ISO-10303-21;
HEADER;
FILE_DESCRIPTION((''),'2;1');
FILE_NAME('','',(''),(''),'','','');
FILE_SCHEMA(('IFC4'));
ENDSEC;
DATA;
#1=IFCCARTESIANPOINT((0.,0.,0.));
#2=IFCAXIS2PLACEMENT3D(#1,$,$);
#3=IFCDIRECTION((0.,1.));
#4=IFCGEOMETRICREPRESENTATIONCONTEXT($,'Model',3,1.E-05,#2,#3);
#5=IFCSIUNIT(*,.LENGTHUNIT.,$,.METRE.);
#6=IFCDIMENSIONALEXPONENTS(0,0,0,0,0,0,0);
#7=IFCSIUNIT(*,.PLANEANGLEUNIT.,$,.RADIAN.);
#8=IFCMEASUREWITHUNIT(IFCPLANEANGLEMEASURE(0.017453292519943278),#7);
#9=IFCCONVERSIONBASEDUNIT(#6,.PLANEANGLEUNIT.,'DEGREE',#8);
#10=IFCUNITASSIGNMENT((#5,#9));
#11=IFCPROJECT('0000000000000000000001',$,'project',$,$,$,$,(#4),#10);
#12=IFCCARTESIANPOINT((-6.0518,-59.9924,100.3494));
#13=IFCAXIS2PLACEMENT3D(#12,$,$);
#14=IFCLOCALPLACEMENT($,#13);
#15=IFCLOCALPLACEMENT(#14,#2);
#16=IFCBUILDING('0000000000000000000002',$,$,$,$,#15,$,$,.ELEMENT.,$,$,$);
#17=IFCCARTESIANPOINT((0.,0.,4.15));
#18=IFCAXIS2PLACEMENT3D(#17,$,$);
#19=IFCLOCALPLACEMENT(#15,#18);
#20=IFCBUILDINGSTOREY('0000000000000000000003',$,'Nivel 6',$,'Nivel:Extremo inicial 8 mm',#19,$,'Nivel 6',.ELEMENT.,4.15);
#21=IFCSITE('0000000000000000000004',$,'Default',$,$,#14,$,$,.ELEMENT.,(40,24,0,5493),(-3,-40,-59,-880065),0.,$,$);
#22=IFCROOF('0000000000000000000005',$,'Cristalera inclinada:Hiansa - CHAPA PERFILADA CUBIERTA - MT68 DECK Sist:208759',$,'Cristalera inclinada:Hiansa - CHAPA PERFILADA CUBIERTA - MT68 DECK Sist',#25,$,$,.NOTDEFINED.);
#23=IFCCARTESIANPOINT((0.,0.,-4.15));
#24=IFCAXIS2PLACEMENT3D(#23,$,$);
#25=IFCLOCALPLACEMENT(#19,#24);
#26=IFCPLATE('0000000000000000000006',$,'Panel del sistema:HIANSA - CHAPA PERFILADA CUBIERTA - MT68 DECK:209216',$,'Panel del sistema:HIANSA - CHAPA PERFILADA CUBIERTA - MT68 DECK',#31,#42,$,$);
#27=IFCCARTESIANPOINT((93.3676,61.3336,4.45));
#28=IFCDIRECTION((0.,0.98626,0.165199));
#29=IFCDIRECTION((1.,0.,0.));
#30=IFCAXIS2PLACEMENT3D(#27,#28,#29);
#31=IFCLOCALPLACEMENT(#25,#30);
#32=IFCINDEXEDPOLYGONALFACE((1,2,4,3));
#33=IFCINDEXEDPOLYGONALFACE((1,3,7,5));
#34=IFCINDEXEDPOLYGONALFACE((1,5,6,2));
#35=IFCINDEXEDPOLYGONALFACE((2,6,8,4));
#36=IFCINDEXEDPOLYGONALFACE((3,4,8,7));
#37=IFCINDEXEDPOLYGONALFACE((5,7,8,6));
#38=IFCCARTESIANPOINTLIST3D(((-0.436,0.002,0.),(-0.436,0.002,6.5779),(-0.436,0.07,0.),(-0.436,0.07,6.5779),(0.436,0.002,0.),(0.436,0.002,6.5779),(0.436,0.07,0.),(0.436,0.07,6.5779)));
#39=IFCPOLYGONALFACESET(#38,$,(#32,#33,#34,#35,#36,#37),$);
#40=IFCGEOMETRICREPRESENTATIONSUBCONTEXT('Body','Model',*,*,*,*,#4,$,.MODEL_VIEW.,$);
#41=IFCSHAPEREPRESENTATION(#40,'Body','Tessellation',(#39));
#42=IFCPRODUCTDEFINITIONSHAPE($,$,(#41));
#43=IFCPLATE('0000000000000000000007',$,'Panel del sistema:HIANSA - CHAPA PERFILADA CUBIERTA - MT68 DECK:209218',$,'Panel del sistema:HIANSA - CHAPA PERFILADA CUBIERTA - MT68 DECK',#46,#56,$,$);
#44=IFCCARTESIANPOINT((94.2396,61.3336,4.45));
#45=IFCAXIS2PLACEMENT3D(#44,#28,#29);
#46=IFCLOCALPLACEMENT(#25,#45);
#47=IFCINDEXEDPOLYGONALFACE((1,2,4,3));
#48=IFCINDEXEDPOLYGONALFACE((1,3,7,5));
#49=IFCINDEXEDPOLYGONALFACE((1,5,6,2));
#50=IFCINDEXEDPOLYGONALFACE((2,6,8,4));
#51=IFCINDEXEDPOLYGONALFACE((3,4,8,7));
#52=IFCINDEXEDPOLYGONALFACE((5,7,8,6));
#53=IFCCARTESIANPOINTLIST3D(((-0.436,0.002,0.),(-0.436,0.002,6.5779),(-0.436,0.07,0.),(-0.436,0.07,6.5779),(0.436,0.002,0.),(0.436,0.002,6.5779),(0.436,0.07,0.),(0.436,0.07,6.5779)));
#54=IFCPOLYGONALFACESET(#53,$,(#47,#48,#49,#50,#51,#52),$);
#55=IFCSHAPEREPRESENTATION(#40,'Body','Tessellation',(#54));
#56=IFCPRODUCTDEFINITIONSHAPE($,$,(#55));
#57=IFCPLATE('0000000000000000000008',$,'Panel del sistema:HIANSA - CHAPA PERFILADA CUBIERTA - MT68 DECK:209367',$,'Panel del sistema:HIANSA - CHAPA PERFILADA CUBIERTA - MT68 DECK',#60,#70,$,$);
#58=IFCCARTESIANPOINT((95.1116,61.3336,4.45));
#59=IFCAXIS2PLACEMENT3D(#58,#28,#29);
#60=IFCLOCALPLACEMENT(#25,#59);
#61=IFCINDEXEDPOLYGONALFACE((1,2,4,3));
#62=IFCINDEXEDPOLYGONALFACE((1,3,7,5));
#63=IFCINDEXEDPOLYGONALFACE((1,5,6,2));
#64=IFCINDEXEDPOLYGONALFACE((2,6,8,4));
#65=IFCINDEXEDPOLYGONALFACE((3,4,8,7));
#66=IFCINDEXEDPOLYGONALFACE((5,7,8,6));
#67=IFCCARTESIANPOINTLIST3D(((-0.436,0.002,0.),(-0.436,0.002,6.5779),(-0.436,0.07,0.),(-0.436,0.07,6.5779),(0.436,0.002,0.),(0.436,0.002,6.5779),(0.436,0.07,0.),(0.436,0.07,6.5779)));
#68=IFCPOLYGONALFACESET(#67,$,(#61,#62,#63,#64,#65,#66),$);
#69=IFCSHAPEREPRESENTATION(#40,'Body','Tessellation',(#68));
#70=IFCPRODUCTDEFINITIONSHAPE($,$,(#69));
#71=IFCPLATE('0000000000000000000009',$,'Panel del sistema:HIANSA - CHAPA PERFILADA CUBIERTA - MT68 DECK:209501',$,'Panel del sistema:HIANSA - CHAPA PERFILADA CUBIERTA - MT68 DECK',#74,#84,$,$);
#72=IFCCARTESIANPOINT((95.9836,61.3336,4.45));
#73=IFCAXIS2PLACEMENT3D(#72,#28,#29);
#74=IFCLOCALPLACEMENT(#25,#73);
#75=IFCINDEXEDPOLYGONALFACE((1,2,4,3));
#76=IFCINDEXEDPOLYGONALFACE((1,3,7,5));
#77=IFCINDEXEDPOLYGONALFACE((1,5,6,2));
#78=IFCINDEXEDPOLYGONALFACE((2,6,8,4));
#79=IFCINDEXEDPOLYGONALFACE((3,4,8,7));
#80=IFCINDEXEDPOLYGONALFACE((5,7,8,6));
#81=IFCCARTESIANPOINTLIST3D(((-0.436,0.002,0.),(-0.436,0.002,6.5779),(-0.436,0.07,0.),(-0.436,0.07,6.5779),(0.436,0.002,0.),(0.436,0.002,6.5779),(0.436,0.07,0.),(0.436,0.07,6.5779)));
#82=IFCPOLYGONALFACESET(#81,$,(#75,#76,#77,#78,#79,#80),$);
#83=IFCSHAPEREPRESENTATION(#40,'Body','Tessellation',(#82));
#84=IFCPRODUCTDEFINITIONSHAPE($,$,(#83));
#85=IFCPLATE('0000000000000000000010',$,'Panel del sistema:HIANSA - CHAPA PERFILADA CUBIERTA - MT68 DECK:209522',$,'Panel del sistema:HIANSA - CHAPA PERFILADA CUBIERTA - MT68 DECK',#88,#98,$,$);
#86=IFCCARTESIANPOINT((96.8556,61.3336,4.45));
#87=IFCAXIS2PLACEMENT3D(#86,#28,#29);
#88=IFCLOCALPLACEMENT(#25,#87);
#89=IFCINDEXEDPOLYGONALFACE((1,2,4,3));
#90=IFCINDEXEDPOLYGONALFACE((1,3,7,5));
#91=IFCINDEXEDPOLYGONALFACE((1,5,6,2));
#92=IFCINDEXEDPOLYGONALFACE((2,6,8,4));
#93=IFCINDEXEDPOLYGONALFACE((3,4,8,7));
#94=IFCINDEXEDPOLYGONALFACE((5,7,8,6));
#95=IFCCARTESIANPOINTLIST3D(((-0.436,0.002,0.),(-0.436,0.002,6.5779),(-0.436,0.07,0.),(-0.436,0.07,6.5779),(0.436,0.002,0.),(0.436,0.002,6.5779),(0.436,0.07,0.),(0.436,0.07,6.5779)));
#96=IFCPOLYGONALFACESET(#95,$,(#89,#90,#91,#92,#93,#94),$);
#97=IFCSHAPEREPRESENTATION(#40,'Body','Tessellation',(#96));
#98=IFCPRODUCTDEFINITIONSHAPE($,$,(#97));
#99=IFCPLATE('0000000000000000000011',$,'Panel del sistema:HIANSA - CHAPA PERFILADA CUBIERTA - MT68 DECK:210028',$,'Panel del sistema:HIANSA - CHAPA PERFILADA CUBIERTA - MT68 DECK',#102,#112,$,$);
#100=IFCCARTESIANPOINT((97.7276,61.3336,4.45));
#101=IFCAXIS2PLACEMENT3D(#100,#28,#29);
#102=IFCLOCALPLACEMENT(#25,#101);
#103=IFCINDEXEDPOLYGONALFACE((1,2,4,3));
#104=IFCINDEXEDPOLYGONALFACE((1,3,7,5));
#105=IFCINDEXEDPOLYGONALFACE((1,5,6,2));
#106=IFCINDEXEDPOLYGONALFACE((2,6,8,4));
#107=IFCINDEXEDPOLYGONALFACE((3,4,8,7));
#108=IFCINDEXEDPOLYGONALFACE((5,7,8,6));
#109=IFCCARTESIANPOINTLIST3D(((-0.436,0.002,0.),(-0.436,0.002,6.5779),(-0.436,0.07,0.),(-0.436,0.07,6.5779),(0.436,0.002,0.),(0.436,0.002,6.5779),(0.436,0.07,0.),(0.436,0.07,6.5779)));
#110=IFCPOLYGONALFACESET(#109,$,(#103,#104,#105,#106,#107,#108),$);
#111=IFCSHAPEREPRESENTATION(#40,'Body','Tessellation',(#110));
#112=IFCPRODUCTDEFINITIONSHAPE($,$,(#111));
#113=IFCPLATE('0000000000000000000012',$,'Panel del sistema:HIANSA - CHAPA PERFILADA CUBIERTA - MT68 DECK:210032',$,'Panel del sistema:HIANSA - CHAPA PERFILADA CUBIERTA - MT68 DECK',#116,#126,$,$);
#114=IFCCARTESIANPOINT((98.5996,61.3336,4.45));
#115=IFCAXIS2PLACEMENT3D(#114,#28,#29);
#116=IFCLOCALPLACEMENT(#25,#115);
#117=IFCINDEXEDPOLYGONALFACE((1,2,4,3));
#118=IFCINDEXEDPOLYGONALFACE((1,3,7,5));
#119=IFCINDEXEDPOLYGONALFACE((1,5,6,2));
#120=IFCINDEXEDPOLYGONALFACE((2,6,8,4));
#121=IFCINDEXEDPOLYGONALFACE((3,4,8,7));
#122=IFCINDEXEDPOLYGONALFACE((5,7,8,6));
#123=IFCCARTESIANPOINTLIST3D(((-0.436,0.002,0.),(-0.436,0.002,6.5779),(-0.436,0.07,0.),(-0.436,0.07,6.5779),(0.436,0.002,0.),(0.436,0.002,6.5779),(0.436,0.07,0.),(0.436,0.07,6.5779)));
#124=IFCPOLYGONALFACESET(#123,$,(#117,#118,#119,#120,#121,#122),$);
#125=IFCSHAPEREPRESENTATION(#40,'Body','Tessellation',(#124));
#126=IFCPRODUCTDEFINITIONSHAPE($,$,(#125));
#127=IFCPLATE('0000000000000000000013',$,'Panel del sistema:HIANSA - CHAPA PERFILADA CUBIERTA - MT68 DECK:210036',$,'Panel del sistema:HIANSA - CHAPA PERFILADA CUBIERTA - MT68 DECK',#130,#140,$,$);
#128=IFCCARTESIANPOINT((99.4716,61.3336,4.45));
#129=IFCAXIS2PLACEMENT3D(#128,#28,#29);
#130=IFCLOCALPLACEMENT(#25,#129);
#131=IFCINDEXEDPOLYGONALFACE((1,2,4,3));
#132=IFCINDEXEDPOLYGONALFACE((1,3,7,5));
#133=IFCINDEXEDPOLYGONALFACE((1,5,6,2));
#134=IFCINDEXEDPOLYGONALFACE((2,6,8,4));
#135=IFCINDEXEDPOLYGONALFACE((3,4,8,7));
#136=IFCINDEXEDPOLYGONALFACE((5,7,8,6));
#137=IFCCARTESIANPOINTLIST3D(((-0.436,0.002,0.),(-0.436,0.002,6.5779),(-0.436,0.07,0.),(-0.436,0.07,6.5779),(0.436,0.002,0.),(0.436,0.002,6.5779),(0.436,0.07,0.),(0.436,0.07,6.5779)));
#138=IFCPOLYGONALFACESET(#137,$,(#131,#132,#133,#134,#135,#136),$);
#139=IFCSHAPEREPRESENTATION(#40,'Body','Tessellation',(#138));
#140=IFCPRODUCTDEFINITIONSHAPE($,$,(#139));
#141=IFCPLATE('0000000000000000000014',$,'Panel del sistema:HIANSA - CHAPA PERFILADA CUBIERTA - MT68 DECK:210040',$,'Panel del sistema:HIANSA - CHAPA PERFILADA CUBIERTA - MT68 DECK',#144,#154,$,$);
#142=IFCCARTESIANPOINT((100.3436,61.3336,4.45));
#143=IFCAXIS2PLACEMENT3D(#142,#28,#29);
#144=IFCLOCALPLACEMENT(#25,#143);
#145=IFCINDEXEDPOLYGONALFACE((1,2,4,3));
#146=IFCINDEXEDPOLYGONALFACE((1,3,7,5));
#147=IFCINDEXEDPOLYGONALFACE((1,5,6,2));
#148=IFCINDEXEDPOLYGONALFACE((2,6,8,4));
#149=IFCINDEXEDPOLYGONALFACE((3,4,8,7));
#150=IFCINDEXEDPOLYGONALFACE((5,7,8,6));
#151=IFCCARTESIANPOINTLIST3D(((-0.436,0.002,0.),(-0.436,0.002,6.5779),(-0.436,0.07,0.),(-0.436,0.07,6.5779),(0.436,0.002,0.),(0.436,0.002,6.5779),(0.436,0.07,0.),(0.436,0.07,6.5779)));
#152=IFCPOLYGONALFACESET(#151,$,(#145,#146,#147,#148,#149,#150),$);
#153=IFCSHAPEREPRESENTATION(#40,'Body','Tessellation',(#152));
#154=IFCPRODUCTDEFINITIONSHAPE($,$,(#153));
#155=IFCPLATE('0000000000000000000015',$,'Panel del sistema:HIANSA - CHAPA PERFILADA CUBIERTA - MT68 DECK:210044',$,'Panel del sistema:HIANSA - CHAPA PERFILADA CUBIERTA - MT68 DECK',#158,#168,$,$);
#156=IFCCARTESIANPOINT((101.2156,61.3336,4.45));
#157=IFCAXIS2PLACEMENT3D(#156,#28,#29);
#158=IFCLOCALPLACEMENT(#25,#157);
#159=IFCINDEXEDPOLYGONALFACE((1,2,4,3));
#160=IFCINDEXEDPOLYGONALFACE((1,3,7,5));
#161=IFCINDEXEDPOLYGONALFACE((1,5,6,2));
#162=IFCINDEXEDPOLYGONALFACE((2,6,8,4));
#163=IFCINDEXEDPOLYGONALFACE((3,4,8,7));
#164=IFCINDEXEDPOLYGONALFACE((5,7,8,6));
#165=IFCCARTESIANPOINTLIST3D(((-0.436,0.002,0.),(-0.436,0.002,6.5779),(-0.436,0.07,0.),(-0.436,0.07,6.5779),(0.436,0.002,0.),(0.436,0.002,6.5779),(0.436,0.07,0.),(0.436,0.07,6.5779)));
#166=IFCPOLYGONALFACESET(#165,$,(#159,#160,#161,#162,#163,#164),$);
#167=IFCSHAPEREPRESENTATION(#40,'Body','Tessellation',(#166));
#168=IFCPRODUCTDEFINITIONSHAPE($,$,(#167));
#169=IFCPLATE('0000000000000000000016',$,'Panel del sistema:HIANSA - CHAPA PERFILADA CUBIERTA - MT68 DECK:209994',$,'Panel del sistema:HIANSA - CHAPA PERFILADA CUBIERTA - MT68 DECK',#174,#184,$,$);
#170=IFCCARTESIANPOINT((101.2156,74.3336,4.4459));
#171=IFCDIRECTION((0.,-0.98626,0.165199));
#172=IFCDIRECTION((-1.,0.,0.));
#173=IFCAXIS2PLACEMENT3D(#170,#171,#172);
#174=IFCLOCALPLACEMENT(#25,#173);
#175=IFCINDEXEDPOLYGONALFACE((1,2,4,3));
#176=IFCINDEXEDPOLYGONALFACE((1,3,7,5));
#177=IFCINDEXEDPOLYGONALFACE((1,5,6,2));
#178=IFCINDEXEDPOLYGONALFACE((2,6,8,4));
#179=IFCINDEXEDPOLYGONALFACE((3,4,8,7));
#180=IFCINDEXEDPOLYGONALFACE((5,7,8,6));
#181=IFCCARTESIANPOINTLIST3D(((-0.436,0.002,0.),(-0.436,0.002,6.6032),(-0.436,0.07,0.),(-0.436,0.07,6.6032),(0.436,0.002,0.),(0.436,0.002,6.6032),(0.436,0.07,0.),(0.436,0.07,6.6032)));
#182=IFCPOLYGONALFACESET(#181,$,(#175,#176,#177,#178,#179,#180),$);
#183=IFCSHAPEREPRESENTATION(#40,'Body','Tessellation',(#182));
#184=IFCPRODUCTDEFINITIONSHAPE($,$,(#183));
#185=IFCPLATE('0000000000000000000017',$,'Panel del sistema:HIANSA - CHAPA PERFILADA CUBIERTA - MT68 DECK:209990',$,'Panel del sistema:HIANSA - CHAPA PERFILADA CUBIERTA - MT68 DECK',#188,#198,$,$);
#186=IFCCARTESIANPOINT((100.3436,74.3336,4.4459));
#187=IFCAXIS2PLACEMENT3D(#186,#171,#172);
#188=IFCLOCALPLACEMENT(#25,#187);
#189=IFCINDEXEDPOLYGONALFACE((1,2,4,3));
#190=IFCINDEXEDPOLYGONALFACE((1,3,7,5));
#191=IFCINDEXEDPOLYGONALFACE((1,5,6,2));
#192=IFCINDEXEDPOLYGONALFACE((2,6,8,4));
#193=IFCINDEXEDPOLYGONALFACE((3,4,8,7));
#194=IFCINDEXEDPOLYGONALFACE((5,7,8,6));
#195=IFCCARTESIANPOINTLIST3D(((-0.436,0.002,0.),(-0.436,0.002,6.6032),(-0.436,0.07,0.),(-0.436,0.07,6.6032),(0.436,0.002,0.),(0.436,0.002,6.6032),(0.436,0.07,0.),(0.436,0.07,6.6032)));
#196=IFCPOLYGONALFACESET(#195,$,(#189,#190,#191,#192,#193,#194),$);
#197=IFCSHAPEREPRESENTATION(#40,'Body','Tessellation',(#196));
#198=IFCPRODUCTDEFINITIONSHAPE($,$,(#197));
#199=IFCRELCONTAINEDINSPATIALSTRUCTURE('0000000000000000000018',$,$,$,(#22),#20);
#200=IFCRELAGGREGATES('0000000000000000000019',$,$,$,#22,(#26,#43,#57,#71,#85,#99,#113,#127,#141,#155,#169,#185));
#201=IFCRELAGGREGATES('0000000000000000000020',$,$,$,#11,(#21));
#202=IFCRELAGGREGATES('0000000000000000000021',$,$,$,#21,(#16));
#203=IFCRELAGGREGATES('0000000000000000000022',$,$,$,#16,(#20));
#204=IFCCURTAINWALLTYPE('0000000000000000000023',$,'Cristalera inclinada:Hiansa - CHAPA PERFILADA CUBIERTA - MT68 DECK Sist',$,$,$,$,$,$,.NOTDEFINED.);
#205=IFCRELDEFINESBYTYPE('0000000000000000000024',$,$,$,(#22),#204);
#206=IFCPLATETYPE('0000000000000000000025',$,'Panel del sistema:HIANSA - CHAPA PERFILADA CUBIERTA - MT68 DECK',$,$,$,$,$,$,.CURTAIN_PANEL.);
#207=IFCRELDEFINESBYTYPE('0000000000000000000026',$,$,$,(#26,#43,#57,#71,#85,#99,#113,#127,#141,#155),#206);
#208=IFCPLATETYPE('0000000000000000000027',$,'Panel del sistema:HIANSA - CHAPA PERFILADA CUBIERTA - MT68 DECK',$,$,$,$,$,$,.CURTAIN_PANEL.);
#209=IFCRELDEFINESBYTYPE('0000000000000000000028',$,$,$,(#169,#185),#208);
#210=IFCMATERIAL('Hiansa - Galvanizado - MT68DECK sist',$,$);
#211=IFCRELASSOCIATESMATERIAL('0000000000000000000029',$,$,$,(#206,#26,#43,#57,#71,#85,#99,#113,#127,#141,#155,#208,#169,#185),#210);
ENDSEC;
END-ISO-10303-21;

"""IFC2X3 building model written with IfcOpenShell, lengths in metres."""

from ifc_helpers import new_model, entity, si_unit, converted_unit, direction, frame, origin, origin_2d_with_axis, place, context, subcontext, project, spatial, rectangle, extrude, source, transform, mapped, material, type_object, type_shapes, element, aggregate, save


model = new_model("IFC2X3")

# Units and contexts
model_context = context("Model", 3, precision=1e-05, world=origin(), true_north=direction((0.0, 1.0)))
body_context = subcontext(model_context, "Body", "Model", "MODEL_VIEW")
ifc_project = project(units=[si_unit("LENGTHUNIT", "METRE"), converted_unit("PLANEANGLEUNIT", "DEGREE", entity("IfcPlaneAngleMeasure", 0.017453292519943278), si_unit("PLANEANGLEUNIT", "RADIAN"), dimensions=[0, 0, 0, 0, 0, 0, 0])], contexts=[model_context])

# Site, building, storey
site_placement = place(None, frame((-6.0518, -59.9924, 100.3494)))
site = spatial("IfcSite", under=ifc_project, at=site_placement, Name="Default", CompositionType="ELEMENT", RefLatitude=(40, 24, 0, 5493), RefLongitude=(-3, -40, -59, -880065), RefElevation=0.0)
building_placement = place(site_placement, origin())
building = spatial("IfcBuilding", under=site, at=building_placement, CompositionType="ELEMENT")
storey_placement = place(building_placement, frame((0.0, 0.0, 4.15)))
storey = spatial("IfcBuildingStorey", under=building, at=storey_placement, Name="Nivel 6", ObjectType="Nivel:Extremo inicial 8 mm", LongName="Nivel 6", CompositionType="ELEMENT", Elevation=4.15)

# Roof, plates
curtain_wall_type = type_object("IfcCurtainWallType", Name="Cristalera inclinada:Hiansa - CHAPA PERFILADA CUBIERTA - MT68 DECK Sist", PredefinedType="NOTDEFINED")
roof_placement = place(storey_placement, frame((0.0, 0.0, -4.15)))
roof = element("IfcRoof", 1, at=roof_placement, inside=storey, type_object=curtain_wall_type, Name="Cristalera inclinada:Hiansa - CHAPA PERFILADA CUBIERTA - MT68 DECK Sist:208759", ObjectType="Cristalera inclinada:Hiansa - CHAPA PERFILADA CUBIERTA - MT68 DECK Sist", ShapeType="NOTDEFINED")
ifc_material_1 = material(Name="Hiansa - Galvanizado - MT68DECK sist")
plate_type_1 = type_object("IfcPlateType", Name="Panel del sistema:HIANSA - CHAPA PERFILADA CUBIERTA - MT68 DECK", PredefinedType="CURTAIN_PANEL", material=ifc_material_1)
shared_shape_1 = source(origin(), body_context, "Body", "SweptSolid", [
    extrude(rectangle(XDim=0.068, YDim=0.872, at=origin_2d_with_axis()), frame((0.0, 0.036, 0.0), z_axis=(0.0, 0.0, 1.0), x_axis=(0.0, 1.0, 0.0)), (0.0, 0.0, 1.0), 6.5779),
])
type_shapes(plate_type_1, [shared_shape_1])
plate_1_placement = place(roof_placement, frame((93.3676, 61.3336, 4.45), z_axis=(0.0, 0.98626, 0.165199), x_axis=(1.0, 0.0, 0.0)))
plate_1 = element("IfcPlate", 2, at=plate_1_placement, type_object=plate_type_1, material=ifc_material_1, Name="Panel del sistema:HIANSA - CHAPA PERFILADA CUBIERTA - MT68 DECK:209216", ObjectType="Panel del sistema:HIANSA - CHAPA PERFILADA CUBIERTA - MT68 DECK", context=body_context, shape_type="MappedRepresentation", body=[
    mapped(shared_shape_1, transform((0.0, 0.0, 0.0), scale=1.0)),
])
plate_2_placement = place(roof_placement, frame((94.2396, 61.3336, 4.45), z_axis=(0.0, 0.98626, 0.165199), x_axis=(1.0, 0.0, 0.0)))
plate_2 = element("IfcPlate", 3, at=plate_2_placement, type_object=plate_type_1, material=ifc_material_1, Name="Panel del sistema:HIANSA - CHAPA PERFILADA CUBIERTA - MT68 DECK:209218", ObjectType="Panel del sistema:HIANSA - CHAPA PERFILADA CUBIERTA - MT68 DECK", context=body_context, shape_type="MappedRepresentation", body=[
    mapped(shared_shape_1, transform((0.0, 0.0, 0.0), scale=1.0)),
])
plate_3_placement = place(roof_placement, frame((95.1116, 61.3336, 4.45), z_axis=(0.0, 0.98626, 0.165199), x_axis=(1.0, 0.0, 0.0)))
plate_3 = element("IfcPlate", 4, at=plate_3_placement, type_object=plate_type_1, material=ifc_material_1, Name="Panel del sistema:HIANSA - CHAPA PERFILADA CUBIERTA - MT68 DECK:209367", ObjectType="Panel del sistema:HIANSA - CHAPA PERFILADA CUBIERTA - MT68 DECK", context=body_context, shape_type="MappedRepresentation", body=[
    mapped(shared_shape_1, transform((0.0, 0.0, 0.0), scale=1.0)),
])
plate_4_placement = place(roof_placement, frame((95.9836, 61.3336, 4.45), z_axis=(0.0, 0.98626, 0.165199), x_axis=(1.0, 0.0, 0.0)))
plate_4 = element("IfcPlate", 5, at=plate_4_placement, type_object=plate_type_1, material=ifc_material_1, Name="Panel del sistema:HIANSA - CHAPA PERFILADA CUBIERTA - MT68 DECK:209501", ObjectType="Panel del sistema:HIANSA - CHAPA PERFILADA CUBIERTA - MT68 DECK", context=body_context, shape_type="MappedRepresentation", body=[
    mapped(shared_shape_1, transform((0.0, 0.0, 0.0), scale=1.0)),
])
plate_5_placement = place(roof_placement, frame((96.8556, 61.3336, 4.45), z_axis=(0.0, 0.98626, 0.165199), x_axis=(1.0, 0.0, 0.0)))
plate_5 = element("IfcPlate", 6, at=plate_5_placement, type_object=plate_type_1, material=ifc_material_1, Name="Panel del sistema:HIANSA - CHAPA PERFILADA CUBIERTA - MT68 DECK:209522", ObjectType="Panel del sistema:HIANSA - CHAPA PERFILADA CUBIERTA - MT68 DECK", context=body_context, shape_type="MappedRepresentation", body=[
    mapped(shared_shape_1, transform((0.0, 0.0, 0.0), scale=1.0)),
])
plate_6_placement = place(roof_placement, frame((97.7276, 61.3336, 4.45), z_axis=(0.0, 0.98626, 0.165199), x_axis=(1.0, 0.0, 0.0)))
plate_6 = element("IfcPlate", 7, at=plate_6_placement, type_object=plate_type_1, material=ifc_material_1, Name="Panel del sistema:HIANSA - CHAPA PERFILADA CUBIERTA - MT68 DECK:210028", ObjectType="Panel del sistema:HIANSA - CHAPA PERFILADA CUBIERTA - MT68 DECK", context=body_context, shape_type="MappedRepresentation", body=[
    mapped(shared_shape_1, transform((0.0, 0.0, 0.0), scale=1.0)),
])
plate_7_placement = place(roof_placement, frame((98.5996, 61.3336, 4.45), z_axis=(0.0, 0.98626, 0.165199), x_axis=(1.0, 0.0, 0.0)))
plate_7 = element("IfcPlate", 8, at=plate_7_placement, type_object=plate_type_1, material=ifc_material_1, Name="Panel del sistema:HIANSA - CHAPA PERFILADA CUBIERTA - MT68 DECK:210032", ObjectType="Panel del sistema:HIANSA - CHAPA PERFILADA CUBIERTA - MT68 DECK", context=body_context, shape_type="MappedRepresentation", body=[
    mapped(shared_shape_1, transform((0.0, 0.0, 0.0), scale=1.0)),
])
plate_8_placement = place(roof_placement, frame((99.4716, 61.3336, 4.45), z_axis=(0.0, 0.98626, 0.165199), x_axis=(1.0, 0.0, 0.0)))
plate_8 = element("IfcPlate", 9, at=plate_8_placement, type_object=plate_type_1, material=ifc_material_1, Name="Panel del sistema:HIANSA - CHAPA PERFILADA CUBIERTA - MT68 DECK:210036", ObjectType="Panel del sistema:HIANSA - CHAPA PERFILADA CUBIERTA - MT68 DECK", context=body_context, shape_type="MappedRepresentation", body=[
    mapped(shared_shape_1, transform((0.0, 0.0, 0.0), scale=1.0)),
])
plate_9_placement = place(roof_placement, frame((100.3436, 61.3336, 4.45), z_axis=(0.0, 0.98626, 0.165199), x_axis=(1.0, 0.0, 0.0)))
plate_9 = element("IfcPlate", 10, at=plate_9_placement, type_object=plate_type_1, material=ifc_material_1, Name="Panel del sistema:HIANSA - CHAPA PERFILADA CUBIERTA - MT68 DECK:210040", ObjectType="Panel del sistema:HIANSA - CHAPA PERFILADA CUBIERTA - MT68 DECK", context=body_context, shape_type="MappedRepresentation", body=[
    mapped(shared_shape_1, transform((0.0, 0.0, 0.0), scale=1.0)),
])
plate_10_placement = place(roof_placement, frame((101.2156, 61.3336, 4.45), z_axis=(0.0, 0.98626, 0.165199), x_axis=(1.0, 0.0, 0.0)))
plate_10 = element("IfcPlate", 11, at=plate_10_placement, type_object=plate_type_1, material=ifc_material_1, Name="Panel del sistema:HIANSA - CHAPA PERFILADA CUBIERTA - MT68 DECK:210044", ObjectType="Panel del sistema:HIANSA - CHAPA PERFILADA CUBIERTA - MT68 DECK", context=body_context, shape_type="MappedRepresentation", body=[
    mapped(shared_shape_1, transform((0.0, 0.0, 0.0), scale=1.0)),
])
plate_type_2 = type_object("IfcPlateType", Name="Panel del sistema:HIANSA - CHAPA PERFILADA CUBIERTA - MT68 DECK", PredefinedType="CURTAIN_PANEL", material=ifc_material_1)
shared_shape_2 = source(origin(), body_context, "Body", "SweptSolid", [
    extrude(rectangle(XDim=0.068, YDim=0.872, at=origin_2d_with_axis()), frame((0.0, 0.036, 0.0), z_axis=(0.0, 0.0, 1.0), x_axis=(0.0, 1.0, 0.0)), (0.0, 0.0, 1.0), 6.6032),
])
type_shapes(plate_type_2, [shared_shape_2])
plate_11_placement = place(roof_placement, frame((101.2156, 74.3336, 4.4459), z_axis=(0.0, -0.98626, 0.165199), x_axis=(-1.0, 0.0, 0.0)))
plate_11 = element("IfcPlate", 12, at=plate_11_placement, type_object=plate_type_2, material=ifc_material_1, Name="Panel del sistema:HIANSA - CHAPA PERFILADA CUBIERTA - MT68 DECK:209994", ObjectType="Panel del sistema:HIANSA - CHAPA PERFILADA CUBIERTA - MT68 DECK", context=body_context, shape_type="MappedRepresentation", body=[
    mapped(shared_shape_2, transform((0.0, 0.0, 0.0), scale=1.0)),
])
plate_12_placement = place(roof_placement, frame((100.3436, 74.3336, 4.4459), z_axis=(0.0, -0.98626, 0.165199), x_axis=(-1.0, 0.0, 0.0)))
plate_12 = element("IfcPlate", 13, at=plate_12_placement, type_object=plate_type_2, material=ifc_material_1, Name="Panel del sistema:HIANSA - CHAPA PERFILADA CUBIERTA - MT68 DECK:209990", ObjectType="Panel del sistema:HIANSA - CHAPA PERFILADA CUBIERTA - MT68 DECK", context=body_context, shape_type="MappedRepresentation", body=[
    mapped(shared_shape_2, transform((0.0, 0.0, 0.0), scale=1.0)),
])
aggregate(roof, [plate_1, plate_2, plate_3, plate_4, plate_5, plate_6, plate_7, plate_8, plate_9, plate_10, plate_11, plate_12])

save(model, "model.ifc")
